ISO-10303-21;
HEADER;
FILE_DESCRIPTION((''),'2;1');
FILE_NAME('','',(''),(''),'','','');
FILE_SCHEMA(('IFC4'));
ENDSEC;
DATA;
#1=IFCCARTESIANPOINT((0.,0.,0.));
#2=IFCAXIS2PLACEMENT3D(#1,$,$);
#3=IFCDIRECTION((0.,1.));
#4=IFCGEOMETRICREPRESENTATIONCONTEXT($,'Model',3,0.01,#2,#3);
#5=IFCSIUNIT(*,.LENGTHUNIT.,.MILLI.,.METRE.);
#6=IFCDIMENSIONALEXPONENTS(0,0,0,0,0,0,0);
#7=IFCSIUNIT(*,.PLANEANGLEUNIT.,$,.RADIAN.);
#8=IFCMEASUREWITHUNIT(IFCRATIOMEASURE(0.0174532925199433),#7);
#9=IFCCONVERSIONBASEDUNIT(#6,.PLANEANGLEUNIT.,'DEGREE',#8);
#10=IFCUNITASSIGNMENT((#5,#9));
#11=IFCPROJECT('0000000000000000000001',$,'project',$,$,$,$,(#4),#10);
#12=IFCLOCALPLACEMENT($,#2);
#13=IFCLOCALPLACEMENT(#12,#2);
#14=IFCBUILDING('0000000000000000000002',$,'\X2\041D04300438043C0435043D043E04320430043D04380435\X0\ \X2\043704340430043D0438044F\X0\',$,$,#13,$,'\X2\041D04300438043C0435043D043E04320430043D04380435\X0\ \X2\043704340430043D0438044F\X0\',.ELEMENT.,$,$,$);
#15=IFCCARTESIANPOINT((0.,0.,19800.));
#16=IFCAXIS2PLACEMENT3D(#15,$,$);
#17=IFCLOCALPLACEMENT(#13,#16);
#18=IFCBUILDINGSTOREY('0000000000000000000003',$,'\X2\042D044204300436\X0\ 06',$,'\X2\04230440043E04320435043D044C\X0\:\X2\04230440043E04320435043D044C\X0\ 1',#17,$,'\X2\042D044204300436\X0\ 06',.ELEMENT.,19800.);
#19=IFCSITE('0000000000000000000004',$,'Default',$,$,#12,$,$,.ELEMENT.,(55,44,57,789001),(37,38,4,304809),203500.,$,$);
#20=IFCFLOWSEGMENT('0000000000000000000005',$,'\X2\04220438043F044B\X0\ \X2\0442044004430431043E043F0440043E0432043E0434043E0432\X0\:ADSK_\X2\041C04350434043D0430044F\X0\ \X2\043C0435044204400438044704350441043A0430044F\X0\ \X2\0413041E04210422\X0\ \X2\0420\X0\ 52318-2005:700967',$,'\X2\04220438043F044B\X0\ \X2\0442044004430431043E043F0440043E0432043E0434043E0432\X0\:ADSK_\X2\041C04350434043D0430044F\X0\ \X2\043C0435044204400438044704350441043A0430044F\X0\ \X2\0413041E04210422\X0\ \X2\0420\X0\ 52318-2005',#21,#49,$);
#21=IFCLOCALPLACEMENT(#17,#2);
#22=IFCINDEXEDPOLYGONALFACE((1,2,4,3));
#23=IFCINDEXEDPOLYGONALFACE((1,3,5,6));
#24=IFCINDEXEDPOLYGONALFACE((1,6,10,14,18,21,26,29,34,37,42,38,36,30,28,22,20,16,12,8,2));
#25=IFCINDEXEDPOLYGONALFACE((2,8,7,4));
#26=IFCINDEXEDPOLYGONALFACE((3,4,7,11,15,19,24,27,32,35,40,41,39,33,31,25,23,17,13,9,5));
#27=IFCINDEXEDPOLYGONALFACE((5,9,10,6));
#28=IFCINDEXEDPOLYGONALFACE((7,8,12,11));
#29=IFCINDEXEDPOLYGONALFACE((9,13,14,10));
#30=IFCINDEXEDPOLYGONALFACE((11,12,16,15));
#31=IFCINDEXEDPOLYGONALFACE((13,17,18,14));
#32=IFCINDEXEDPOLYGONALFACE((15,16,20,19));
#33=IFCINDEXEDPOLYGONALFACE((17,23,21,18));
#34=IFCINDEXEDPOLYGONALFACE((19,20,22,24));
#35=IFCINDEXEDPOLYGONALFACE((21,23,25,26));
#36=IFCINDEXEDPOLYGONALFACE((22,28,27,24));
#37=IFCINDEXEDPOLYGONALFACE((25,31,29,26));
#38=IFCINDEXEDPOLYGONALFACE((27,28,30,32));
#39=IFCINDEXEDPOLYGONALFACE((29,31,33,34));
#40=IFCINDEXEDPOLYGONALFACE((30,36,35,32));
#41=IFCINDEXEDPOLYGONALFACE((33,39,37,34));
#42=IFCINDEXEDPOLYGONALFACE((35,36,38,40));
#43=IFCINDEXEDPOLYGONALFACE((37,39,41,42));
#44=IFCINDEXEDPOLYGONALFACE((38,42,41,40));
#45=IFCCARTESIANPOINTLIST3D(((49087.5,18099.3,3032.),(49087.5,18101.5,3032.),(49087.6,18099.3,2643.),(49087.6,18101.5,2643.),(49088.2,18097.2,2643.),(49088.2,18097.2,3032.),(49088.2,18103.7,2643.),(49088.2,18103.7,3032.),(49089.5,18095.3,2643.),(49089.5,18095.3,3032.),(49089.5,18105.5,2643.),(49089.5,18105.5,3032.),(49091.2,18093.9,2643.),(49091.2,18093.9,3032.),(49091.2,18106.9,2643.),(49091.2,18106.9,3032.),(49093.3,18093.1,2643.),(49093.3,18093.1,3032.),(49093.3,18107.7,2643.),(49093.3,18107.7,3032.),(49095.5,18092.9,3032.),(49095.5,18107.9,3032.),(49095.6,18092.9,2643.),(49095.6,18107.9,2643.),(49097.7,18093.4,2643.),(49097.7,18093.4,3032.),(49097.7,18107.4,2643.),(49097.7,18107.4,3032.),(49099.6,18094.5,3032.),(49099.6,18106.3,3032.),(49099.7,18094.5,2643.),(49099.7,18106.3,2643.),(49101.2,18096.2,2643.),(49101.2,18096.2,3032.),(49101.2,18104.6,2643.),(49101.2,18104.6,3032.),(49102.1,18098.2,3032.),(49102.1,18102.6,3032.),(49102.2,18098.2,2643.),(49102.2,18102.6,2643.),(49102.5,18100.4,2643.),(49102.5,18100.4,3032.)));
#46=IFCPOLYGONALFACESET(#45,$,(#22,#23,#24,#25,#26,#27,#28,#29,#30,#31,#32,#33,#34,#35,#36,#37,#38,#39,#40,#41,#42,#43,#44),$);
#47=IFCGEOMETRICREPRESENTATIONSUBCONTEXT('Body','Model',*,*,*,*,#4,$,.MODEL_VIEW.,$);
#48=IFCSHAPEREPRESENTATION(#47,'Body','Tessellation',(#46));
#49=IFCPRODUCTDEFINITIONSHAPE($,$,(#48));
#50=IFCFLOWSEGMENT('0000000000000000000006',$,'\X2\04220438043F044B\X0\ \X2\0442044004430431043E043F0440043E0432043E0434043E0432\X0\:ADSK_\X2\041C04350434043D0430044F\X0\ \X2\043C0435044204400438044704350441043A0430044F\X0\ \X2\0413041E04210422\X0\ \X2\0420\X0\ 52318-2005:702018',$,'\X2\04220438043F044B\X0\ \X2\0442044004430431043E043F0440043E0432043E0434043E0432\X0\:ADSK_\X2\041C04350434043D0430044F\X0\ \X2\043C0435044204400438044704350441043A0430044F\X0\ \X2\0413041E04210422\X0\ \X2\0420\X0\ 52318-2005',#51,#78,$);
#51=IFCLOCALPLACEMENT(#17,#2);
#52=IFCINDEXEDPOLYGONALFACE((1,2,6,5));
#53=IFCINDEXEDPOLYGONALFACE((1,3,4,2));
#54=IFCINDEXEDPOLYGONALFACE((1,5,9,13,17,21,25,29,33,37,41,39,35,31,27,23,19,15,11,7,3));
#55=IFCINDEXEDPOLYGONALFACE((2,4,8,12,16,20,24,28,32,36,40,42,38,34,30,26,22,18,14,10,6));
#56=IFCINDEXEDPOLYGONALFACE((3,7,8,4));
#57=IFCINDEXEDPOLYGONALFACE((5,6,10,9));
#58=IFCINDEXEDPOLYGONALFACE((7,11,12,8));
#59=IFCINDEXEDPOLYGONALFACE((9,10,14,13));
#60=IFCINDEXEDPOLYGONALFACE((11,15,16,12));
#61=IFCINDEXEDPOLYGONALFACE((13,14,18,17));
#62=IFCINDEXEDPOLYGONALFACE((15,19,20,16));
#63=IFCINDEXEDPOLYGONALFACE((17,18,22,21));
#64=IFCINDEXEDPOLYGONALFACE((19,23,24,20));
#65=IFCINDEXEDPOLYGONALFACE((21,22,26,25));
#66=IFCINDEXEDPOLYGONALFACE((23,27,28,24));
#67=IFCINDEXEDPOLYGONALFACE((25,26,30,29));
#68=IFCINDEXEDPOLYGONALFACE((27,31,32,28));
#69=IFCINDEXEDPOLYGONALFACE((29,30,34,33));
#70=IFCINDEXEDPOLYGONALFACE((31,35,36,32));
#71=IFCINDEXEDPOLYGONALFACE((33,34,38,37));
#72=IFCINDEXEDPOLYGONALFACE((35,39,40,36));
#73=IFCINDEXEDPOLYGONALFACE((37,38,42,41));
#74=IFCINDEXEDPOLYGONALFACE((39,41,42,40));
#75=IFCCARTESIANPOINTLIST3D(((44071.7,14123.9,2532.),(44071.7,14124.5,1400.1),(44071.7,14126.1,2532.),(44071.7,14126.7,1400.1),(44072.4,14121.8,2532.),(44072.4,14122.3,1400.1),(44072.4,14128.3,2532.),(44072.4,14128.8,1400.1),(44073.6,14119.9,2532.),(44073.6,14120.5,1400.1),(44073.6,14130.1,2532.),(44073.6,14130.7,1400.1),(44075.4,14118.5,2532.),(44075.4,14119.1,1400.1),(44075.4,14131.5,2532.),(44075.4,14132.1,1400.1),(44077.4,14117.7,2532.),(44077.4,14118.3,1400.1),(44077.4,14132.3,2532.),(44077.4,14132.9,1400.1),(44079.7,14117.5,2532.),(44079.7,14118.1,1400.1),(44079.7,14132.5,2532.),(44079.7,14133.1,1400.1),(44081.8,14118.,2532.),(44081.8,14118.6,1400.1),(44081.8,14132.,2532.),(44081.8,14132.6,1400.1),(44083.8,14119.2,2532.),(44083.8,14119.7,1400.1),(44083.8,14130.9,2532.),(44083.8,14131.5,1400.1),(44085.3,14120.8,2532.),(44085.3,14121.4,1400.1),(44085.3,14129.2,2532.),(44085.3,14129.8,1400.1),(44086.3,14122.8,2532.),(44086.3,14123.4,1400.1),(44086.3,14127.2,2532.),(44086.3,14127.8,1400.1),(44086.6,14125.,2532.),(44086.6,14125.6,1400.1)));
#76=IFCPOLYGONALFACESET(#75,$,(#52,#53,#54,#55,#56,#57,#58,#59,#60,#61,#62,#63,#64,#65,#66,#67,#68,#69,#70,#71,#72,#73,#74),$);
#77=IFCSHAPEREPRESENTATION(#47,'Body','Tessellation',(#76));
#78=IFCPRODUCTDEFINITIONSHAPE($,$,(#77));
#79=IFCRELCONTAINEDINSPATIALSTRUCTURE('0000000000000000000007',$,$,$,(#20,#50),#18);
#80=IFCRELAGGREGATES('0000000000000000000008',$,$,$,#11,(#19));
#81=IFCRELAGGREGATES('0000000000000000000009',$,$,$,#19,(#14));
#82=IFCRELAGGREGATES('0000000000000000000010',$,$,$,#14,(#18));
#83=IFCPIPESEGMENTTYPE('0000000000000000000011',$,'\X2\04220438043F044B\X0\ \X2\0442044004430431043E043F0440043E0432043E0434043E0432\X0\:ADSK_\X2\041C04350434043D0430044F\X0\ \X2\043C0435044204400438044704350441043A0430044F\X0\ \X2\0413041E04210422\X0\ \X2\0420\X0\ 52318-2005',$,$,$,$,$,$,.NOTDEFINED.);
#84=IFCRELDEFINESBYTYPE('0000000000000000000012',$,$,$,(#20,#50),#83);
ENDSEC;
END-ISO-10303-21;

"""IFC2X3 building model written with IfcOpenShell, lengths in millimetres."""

from ifc_helpers import new_model, entity, si_unit, converted_unit, direction, frame, frame_2d, origin, origin_2d_with_axis, place, context, subcontext, project, spatial, circle, extrude, type_object, element, save


model = new_model("IFC2X3")

# Units and contexts
model_context = context("Model", 3, precision=0.01, world=origin(), true_north=direction((0.0, 1.0)))
body_context = subcontext(model_context, "Body", "Model", "MODEL_VIEW")
ifc_project = project(units=[si_unit("LENGTHUNIT", "METRE", prefix="MILLI"), converted_unit("PLANEANGLEUNIT", "DEGREE", entity("IfcRatioMeasure", 0.0174532925199433), si_unit("PLANEANGLEUNIT", "RADIAN"), dimensions=[0, 0, 0, 0, 0, 0, 0])], contexts=[model_context])

# Site, building, storey
site_placement = place(None, frame((0.0, 0.0, 0.0)))
site = spatial("IfcSite", under=ifc_project, at=site_placement, Name="Default", CompositionType="ELEMENT", RefLatitude=(55, 44, 57, 789001), RefLongitude=(37, 38, 4, 304809), RefElevation=203500.0)
building_placement = place(site_placement, origin())
building = spatial("IfcBuilding", under=site, at=building_placement, Name="Наименование здания", LongName="Наименование здания", CompositionType="ELEMENT")
storey_placement = place(building_placement, frame((0.0, 0.0, 19800.0)))
storey = spatial("IfcBuildingStorey", under=building, at=storey_placement, Name="Этаж 06", ObjectType="Уровень:Уровень 1", LongName="Этаж 06", CompositionType="ELEMENT", Elevation=19800.0)

# Flow segments
pipe_segment_type = type_object("IfcPipeSegmentType", Name="Типы трубопроводов:ADSK_Медная метрическая ГОСТ Р 52318-2005", PredefinedType="NOTDEFINED")
flow_segment_1_placement = place(storey_placement, frame((49085.9, 18091.3, 2643.0)))
element("IfcFlowSegment", 1, at=flow_segment_1_placement, inside=storey, type_object=pipe_segment_type, Name="Типы трубопроводов:ADSK_Медная метрическая ГОСТ Р 52318-2005:700967", ObjectType="Типы трубопроводов:ADSK_Медная метрическая ГОСТ Р 52318-2005", context=body_context, shape_type="SweptSolid", body=[
    extrude(circle(Radius=7.5, at=frame_2d((0.0, 0.0), x_axis=(1.0, 0.0))), frame((9.1, 9.1, 0.0), z_axis=(-0.000095, 0.0, 1.0), x_axis=(1.0, 0.0, 0.000095)), (0.0, 0.0, 1.0), 389.0),
])
flow_segment_2_placement = place(storey_placement, frame((44070.0, 14115.9, 1400.1)))
element("IfcFlowSegment", 2, at=flow_segment_2_placement, inside=storey, type_object=pipe_segment_type, Name="Типы трубопроводов:ADSK_Медная метрическая ГОСТ Р 52318-2005:702018", ObjectType="Типы трубопроводов:ADSK_Медная метрическая ГОСТ Р 52318-2005", context=body_context, shape_type="SweptSolid", body=[
    extrude(circle(Radius=7.5, at=origin_2d_with_axis()), frame((9.1, 9.7, 0.0), z_axis=(0.0, -0.000501, 1.0), x_axis=(1.0, 0.0, 0.0)), (0.0, 0.0, 1.0), 1131.9),
])

save(model, "model.ifc")
